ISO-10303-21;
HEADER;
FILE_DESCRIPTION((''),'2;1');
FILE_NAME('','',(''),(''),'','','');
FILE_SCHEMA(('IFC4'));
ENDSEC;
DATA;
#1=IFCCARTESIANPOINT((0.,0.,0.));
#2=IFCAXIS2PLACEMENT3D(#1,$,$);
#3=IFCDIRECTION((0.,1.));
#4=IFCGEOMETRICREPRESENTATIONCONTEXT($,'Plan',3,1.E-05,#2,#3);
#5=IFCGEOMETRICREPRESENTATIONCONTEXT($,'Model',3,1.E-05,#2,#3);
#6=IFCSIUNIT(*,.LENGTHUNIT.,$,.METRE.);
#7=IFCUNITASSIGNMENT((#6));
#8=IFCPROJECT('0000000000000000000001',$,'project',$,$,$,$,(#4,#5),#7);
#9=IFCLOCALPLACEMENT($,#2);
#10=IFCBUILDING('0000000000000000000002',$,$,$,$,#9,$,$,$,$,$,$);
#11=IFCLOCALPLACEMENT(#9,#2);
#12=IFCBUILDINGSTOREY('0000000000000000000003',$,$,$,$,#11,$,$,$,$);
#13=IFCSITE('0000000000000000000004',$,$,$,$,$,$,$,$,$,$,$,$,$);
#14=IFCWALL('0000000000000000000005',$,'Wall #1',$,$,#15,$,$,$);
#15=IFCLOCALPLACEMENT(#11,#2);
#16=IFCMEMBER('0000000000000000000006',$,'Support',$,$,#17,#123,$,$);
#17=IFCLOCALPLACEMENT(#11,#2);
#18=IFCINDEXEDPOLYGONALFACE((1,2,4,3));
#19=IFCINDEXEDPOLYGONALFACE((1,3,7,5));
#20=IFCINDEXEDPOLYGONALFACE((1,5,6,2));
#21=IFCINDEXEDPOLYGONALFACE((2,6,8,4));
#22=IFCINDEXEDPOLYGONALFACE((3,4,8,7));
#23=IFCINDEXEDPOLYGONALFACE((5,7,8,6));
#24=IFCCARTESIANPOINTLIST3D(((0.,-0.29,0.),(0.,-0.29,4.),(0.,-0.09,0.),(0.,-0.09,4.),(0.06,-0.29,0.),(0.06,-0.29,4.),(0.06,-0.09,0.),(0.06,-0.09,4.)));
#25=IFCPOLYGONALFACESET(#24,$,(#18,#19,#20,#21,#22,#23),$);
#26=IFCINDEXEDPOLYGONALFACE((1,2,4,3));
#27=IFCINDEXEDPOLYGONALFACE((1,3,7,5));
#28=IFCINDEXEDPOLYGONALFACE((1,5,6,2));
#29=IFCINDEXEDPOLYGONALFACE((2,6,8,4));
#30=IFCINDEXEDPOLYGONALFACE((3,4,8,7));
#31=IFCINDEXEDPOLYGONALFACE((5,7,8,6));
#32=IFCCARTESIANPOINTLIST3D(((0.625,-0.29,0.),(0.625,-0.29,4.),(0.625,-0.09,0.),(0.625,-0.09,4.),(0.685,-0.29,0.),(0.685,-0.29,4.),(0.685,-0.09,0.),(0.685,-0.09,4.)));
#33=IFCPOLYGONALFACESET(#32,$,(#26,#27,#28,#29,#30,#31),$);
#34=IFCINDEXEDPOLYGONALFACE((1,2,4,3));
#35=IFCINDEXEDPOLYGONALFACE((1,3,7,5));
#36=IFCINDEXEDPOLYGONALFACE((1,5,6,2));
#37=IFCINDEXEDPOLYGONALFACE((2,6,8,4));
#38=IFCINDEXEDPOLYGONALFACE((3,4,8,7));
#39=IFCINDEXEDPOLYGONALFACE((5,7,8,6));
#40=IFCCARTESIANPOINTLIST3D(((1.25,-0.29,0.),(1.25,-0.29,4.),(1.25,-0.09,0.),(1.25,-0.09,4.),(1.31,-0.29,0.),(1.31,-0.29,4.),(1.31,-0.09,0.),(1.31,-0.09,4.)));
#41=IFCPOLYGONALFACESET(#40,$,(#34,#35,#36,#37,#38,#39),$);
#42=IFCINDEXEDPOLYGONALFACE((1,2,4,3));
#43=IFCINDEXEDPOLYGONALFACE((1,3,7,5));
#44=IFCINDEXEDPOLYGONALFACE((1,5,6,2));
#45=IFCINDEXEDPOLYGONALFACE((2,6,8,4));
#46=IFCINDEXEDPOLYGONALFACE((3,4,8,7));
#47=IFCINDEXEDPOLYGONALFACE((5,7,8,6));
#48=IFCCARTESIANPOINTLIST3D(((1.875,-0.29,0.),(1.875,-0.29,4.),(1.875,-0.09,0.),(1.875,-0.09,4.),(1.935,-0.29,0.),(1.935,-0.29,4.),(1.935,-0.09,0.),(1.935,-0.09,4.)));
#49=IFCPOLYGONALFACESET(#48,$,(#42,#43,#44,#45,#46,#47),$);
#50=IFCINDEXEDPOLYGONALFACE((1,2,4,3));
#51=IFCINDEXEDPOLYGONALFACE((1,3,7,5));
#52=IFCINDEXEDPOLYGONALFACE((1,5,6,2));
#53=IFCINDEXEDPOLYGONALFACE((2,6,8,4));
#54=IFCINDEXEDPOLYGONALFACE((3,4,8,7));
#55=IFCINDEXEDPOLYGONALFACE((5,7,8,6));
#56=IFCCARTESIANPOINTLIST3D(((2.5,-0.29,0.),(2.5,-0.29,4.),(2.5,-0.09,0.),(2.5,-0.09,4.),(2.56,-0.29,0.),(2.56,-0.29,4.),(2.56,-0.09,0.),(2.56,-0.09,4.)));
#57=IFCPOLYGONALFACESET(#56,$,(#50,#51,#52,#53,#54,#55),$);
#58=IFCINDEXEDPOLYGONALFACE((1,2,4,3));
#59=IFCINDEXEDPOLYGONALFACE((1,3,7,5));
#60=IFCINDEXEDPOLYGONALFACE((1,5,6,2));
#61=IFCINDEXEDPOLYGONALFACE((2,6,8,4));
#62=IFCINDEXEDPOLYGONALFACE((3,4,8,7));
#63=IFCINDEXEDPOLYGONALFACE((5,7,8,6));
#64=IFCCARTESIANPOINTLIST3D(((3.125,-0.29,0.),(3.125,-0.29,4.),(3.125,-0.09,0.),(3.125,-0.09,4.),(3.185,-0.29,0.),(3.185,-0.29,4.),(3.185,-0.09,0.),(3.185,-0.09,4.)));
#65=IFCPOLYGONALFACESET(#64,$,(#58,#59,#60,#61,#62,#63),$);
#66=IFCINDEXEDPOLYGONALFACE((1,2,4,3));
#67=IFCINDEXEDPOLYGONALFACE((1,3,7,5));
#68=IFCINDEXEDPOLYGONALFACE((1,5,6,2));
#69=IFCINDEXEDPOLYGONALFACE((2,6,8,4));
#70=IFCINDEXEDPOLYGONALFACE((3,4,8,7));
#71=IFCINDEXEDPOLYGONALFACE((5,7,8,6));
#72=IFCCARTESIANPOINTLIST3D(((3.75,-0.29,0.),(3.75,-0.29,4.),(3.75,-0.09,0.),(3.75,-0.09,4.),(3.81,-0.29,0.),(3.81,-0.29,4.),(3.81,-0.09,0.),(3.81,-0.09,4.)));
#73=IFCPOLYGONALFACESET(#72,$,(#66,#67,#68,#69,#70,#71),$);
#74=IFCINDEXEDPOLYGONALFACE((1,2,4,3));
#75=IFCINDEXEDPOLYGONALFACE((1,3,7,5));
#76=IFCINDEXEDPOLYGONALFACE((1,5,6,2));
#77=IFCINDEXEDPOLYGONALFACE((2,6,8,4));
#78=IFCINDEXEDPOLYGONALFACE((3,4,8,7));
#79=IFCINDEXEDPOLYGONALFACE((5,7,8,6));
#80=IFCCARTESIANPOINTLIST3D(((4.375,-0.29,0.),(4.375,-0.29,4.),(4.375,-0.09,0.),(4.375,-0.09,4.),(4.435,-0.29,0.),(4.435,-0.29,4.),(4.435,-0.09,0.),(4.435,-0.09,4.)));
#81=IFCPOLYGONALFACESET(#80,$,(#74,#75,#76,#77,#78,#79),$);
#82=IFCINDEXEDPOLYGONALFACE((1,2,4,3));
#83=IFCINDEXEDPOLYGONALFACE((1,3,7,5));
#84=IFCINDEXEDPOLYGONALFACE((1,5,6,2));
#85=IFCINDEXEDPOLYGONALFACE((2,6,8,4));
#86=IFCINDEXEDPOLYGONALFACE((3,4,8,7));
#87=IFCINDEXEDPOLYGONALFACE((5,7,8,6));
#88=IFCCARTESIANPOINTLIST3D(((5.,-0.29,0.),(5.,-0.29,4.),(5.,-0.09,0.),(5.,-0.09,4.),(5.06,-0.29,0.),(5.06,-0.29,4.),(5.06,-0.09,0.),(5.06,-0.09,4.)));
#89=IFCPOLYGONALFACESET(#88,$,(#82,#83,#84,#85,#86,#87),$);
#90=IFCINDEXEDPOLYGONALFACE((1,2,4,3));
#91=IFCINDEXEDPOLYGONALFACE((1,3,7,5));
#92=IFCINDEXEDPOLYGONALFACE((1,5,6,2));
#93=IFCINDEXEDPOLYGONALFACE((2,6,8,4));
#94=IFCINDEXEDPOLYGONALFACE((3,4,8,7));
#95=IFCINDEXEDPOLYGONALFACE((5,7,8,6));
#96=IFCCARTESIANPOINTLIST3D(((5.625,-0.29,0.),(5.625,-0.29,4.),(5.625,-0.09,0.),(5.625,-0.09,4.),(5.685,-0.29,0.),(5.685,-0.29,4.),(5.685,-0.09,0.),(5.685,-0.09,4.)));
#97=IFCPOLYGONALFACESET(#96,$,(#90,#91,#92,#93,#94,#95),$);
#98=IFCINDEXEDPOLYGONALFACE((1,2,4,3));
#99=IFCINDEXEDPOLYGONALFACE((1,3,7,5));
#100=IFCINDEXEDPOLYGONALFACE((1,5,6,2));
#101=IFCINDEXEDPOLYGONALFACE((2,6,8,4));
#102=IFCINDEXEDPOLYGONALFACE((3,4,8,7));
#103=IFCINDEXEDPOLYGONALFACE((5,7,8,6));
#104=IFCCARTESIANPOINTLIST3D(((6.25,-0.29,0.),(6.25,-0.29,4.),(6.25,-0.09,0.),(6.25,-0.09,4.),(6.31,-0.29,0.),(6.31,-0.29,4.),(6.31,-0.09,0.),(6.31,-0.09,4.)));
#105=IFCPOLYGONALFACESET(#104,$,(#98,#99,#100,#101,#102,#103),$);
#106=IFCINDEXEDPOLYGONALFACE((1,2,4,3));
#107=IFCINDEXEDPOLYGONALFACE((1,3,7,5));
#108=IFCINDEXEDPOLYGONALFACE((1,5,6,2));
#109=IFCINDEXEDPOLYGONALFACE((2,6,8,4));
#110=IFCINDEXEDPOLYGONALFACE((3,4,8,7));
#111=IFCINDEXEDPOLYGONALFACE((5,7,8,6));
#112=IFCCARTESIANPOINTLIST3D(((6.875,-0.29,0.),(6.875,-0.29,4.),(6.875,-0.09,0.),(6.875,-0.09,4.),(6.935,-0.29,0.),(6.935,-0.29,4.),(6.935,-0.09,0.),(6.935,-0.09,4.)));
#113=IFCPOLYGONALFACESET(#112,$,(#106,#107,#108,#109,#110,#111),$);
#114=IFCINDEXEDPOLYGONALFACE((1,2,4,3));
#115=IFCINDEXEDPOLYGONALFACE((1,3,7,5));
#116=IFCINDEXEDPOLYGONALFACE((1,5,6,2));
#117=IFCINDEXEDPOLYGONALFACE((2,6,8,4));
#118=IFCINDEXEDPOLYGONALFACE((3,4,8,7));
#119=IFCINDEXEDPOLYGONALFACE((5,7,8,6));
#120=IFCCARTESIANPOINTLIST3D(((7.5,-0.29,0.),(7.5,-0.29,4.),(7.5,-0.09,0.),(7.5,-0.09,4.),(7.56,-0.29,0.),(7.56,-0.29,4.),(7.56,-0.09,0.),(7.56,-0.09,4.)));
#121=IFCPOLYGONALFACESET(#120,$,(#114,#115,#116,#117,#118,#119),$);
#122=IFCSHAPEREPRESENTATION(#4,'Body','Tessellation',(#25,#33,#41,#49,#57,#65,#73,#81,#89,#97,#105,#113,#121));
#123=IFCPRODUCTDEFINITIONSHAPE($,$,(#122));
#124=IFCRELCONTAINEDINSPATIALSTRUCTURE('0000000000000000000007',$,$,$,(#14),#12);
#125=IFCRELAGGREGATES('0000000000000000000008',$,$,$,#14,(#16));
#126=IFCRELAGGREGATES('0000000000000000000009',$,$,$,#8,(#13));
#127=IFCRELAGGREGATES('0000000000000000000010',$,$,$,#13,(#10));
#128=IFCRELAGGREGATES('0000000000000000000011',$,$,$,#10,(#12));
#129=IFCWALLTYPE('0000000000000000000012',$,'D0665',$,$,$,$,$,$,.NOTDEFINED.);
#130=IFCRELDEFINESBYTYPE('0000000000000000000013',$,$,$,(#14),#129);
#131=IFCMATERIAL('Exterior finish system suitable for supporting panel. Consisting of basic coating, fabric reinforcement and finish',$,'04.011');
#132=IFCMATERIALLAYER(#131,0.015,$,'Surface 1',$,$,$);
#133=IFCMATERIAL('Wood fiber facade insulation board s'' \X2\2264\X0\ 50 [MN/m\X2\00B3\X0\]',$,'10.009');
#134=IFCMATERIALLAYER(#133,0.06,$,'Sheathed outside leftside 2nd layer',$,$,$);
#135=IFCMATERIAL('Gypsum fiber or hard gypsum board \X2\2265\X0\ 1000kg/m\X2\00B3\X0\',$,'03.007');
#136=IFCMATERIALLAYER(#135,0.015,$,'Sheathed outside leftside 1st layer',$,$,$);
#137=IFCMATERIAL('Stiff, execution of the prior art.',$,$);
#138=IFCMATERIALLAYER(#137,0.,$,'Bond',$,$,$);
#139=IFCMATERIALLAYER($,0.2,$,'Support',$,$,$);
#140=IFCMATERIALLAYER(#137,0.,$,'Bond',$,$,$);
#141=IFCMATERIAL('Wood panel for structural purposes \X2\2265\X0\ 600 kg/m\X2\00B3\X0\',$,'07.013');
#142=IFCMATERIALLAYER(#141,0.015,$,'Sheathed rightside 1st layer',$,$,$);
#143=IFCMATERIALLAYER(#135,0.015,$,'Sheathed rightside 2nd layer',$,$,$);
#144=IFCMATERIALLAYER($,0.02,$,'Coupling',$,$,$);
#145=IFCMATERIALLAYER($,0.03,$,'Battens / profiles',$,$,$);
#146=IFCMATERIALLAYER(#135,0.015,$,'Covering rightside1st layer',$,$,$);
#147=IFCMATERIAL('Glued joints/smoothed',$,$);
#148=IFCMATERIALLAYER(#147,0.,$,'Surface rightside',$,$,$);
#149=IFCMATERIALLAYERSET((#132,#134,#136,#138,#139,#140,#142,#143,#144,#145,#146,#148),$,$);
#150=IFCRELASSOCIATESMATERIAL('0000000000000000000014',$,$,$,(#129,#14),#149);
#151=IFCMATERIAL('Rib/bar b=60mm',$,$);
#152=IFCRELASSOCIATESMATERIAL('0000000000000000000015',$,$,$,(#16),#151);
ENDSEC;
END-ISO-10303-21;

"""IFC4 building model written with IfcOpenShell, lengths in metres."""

from ifc_helpers import new_model, si_unit, direction, frame, frame_2d, origin, place, context, project, spatial, rectangle, extrude, material, layer, layer_set, type_object, element, aggregate, save


model = new_model("IFC4")

# Units and contexts
plan_context = context("Plan", 3, precision=1e-05, world=origin(), true_north=direction((0.0, 1.0)))
model_context = context("Model", 3, precision=1e-05, world=origin(), true_north=direction((0.0, 1.0)))
ifc_project = project(units=[si_unit("LENGTHUNIT", "METRE")], contexts=[plan_context, model_context])

# Site, building, storey
site = spatial("IfcSite", under=ifc_project)
building_placement = place(None, origin())
building = spatial("IfcBuilding", under=site, at=building_placement)
storey_placement = place(building_placement, origin())
storey = spatial("IfcBuildingStorey", under=building, at=storey_placement)

# Wall, member
ifc_material_1 = material(Name="Exterior finish system suitable for supporting panel. Consisting of basic coating, fabric reinforcement and finish", Category="04.011")
ifc_layer_1 = layer(ifc_material_1, 0.015, Name="Surface 1")
ifc_material_2 = material(Name="Wood fiber facade insulation board s' ≤ 50 [MN/m³]", Category="10.009")
ifc_layer_2 = layer(ifc_material_2, 0.06, Name="Sheathed outside leftside 2nd layer")
ifc_material_3 = material(Name="Gypsum fiber or hard gypsum board ≥ 1000kg/m³", Category="03.007")
ifc_layer_3 = layer(ifc_material_3, 0.015, Name="Sheathed outside leftside 1st layer")
ifc_material_4 = material(Name="Stiff, execution of the prior art.")
ifc_layer_4 = layer(ifc_material_4, 0.0, Name="Bond")
ifc_layer_5 = layer(None, 0.2, Name="Support")
ifc_layer_6 = layer(ifc_material_4, 0.0, Name="Bond")
ifc_material_5 = material(Name="Wood panel for structural purposes ≥ 600 kg/m³", Category="07.013")
ifc_layer_7 = layer(ifc_material_5, 0.015, Name="Sheathed rightside 1st layer")
ifc_layer_8 = layer(ifc_material_3, 0.015, Name="Sheathed rightside 2nd layer")
ifc_layer_9 = layer(None, 0.02, Name="Coupling")
ifc_layer_10 = layer(None, 0.03, Name="Battens / profiles")
ifc_layer_11 = layer(ifc_material_3, 0.015, Name="Covering rightside1st layer")
ifc_material_6 = material(Name="Glued joints/smoothed")
ifc_layer_12 = layer(ifc_material_6, 0.0, Name="Surface rightside")
ifc_layer_set = layer_set([ifc_layer_1, ifc_layer_2, ifc_layer_3, ifc_layer_4, ifc_layer_5, ifc_layer_6, ifc_layer_7, ifc_layer_8, ifc_layer_9, ifc_layer_10, ifc_layer_11, ifc_layer_12])
wall_type = type_object("IfcWallType", Name="D0665", PredefinedType="NOTDEFINED", material=ifc_layer_set)
wall_placement = place(None, frame((0.0, 0.0, 0.0), z_axis=(0.0, -1.0, 0.0), x_axis=(1.0, 0.0, 0.0)))
wall = element("IfcWall", 1, at=wall_placement, inside=storey, type_object=wall_type, material=ifc_layer_set, Name="Wall #1")
ifc_material_7 = material(Name="Rib/bar b=60mm")
member_1_placement = place(wall_placement, origin())
member_1 = element("IfcMember", 2, at=member_1_placement, material=ifc_material_7, Name="Support", context=plan_context, shape_type="SweptSolid", body=[
    extrude(rectangle(XDim=0.06, YDim=0.2, at=frame_2d((0.03, 0.1), x_axis=(1.0, 0.0))), frame((0.0, 4.0, 0.09), z_axis=(0.0, -1.0, 0.0), x_axis=(1.0, 0.0, 0.0)), (0.0, 0.0, 1.0), 4.0),
    extrude(rectangle(XDim=0.06, YDim=0.2, at=frame_2d((0.03, 0.1), x_axis=(1.0, 0.0))), frame((0.625, 4.0, 0.09), z_axis=(0.0, -1.0, 0.0), x_axis=(1.0, 0.0, 0.0)), (0.0, 0.0, 1.0), 4.0),
    extrude(rectangle(XDim=0.06, YDim=0.2, at=frame_2d((0.03, 0.1), x_axis=(1.0, 0.0))), frame((1.25, 4.0, 0.09), z_axis=(0.0, -1.0, 0.0), x_axis=(1.0, 0.0, 0.0)), (0.0, 0.0, 1.0), 4.0),
    extrude(rectangle(XDim=0.06, YDim=0.2, at=frame_2d((0.03, 0.1), x_axis=(1.0, 0.0))), frame((1.875, 4.0, 0.09), z_axis=(0.0, -1.0, 0.0), x_axis=(1.0, 0.0, 0.0)), (0.0, 0.0, 1.0), 4.0),
    extrude(rectangle(XDim=0.06, YDim=0.2, at=frame_2d((0.03, 0.1), x_axis=(1.0, 0.0))), frame((2.5, 4.0, 0.09), z_axis=(0.0, -1.0, 0.0), x_axis=(1.0, 0.0, 0.0)), (0.0, 0.0, 1.0), 4.0),
    extrude(rectangle(XDim=0.06, YDim=0.2, at=frame_2d((0.03, 0.1), x_axis=(1.0, 0.0))), frame((3.125, 4.0, 0.09), z_axis=(0.0, -1.0, 0.0), x_axis=(1.0, 0.0, 0.0)), (0.0, 0.0, 1.0), 4.0),
    extrude(rectangle(XDim=0.06, YDim=0.2, at=frame_2d((0.03, 0.1), x_axis=(1.0, 0.0))), frame((3.75, 4.0, 0.09), z_axis=(0.0, -1.0, 0.0), x_axis=(1.0, 0.0, 0.0)), (0.0, 0.0, 1.0), 4.0),
    extrude(rectangle(XDim=0.06, YDim=0.2, at=frame_2d((0.03, 0.1), x_axis=(1.0, 0.0))), frame((4.375, 4.0, 0.09), z_axis=(0.0, -1.0, 0.0), x_axis=(1.0, 0.0, 0.0)), (0.0, 0.0, 1.0), 4.0),
    extrude(rectangle(XDim=0.06, YDim=0.2, at=frame_2d((0.03, 0.1), x_axis=(1.0, 0.0))), frame((5.0, 4.0, 0.09), z_axis=(0.0, -1.0, 0.0), x_axis=(1.0, 0.0, 0.0)), (0.0, 0.0, 1.0), 4.0),
    extrude(rectangle(XDim=0.06, YDim=0.2, at=frame_2d((0.03, 0.1), x_axis=(1.0, 0.0))), frame((5.625, 4.0, 0.09), z_axis=(0.0, -1.0, 0.0), x_axis=(1.0, 0.0, 0.0)), (0.0, 0.0, 1.0), 4.0),
    extrude(rectangle(XDim=0.06, YDim=0.2, at=frame_2d((0.03, 0.1), x_axis=(1.0, 0.0))), frame((6.25, 4.0, 0.09), z_axis=(0.0, -1.0, 0.0), x_axis=(1.0, 0.0, 0.0)), (0.0, 0.0, 1.0), 4.0),
    extrude(rectangle(XDim=0.06, YDim=0.2, at=frame_2d((0.03, 0.1), x_axis=(1.0, 0.0))), frame((6.875, 4.0, 0.09), z_axis=(0.0, -1.0, 0.0), x_axis=(1.0, 0.0, 0.0)), (0.0, 0.0, 1.0), 4.0),
    extrude(rectangle(XDim=0.06, YDim=0.2, at=frame_2d((0.03, 0.1), x_axis=(1.0, 0.0))), frame((7.5, 4.0, 0.09), z_axis=(0.0, -1.0, 0.0), x_axis=(1.0, 0.0, 0.0)), (0.0, 0.0, 1.0), 4.0),
])
aggregate(wall, [member_1])

save(model, "model.ifc")
